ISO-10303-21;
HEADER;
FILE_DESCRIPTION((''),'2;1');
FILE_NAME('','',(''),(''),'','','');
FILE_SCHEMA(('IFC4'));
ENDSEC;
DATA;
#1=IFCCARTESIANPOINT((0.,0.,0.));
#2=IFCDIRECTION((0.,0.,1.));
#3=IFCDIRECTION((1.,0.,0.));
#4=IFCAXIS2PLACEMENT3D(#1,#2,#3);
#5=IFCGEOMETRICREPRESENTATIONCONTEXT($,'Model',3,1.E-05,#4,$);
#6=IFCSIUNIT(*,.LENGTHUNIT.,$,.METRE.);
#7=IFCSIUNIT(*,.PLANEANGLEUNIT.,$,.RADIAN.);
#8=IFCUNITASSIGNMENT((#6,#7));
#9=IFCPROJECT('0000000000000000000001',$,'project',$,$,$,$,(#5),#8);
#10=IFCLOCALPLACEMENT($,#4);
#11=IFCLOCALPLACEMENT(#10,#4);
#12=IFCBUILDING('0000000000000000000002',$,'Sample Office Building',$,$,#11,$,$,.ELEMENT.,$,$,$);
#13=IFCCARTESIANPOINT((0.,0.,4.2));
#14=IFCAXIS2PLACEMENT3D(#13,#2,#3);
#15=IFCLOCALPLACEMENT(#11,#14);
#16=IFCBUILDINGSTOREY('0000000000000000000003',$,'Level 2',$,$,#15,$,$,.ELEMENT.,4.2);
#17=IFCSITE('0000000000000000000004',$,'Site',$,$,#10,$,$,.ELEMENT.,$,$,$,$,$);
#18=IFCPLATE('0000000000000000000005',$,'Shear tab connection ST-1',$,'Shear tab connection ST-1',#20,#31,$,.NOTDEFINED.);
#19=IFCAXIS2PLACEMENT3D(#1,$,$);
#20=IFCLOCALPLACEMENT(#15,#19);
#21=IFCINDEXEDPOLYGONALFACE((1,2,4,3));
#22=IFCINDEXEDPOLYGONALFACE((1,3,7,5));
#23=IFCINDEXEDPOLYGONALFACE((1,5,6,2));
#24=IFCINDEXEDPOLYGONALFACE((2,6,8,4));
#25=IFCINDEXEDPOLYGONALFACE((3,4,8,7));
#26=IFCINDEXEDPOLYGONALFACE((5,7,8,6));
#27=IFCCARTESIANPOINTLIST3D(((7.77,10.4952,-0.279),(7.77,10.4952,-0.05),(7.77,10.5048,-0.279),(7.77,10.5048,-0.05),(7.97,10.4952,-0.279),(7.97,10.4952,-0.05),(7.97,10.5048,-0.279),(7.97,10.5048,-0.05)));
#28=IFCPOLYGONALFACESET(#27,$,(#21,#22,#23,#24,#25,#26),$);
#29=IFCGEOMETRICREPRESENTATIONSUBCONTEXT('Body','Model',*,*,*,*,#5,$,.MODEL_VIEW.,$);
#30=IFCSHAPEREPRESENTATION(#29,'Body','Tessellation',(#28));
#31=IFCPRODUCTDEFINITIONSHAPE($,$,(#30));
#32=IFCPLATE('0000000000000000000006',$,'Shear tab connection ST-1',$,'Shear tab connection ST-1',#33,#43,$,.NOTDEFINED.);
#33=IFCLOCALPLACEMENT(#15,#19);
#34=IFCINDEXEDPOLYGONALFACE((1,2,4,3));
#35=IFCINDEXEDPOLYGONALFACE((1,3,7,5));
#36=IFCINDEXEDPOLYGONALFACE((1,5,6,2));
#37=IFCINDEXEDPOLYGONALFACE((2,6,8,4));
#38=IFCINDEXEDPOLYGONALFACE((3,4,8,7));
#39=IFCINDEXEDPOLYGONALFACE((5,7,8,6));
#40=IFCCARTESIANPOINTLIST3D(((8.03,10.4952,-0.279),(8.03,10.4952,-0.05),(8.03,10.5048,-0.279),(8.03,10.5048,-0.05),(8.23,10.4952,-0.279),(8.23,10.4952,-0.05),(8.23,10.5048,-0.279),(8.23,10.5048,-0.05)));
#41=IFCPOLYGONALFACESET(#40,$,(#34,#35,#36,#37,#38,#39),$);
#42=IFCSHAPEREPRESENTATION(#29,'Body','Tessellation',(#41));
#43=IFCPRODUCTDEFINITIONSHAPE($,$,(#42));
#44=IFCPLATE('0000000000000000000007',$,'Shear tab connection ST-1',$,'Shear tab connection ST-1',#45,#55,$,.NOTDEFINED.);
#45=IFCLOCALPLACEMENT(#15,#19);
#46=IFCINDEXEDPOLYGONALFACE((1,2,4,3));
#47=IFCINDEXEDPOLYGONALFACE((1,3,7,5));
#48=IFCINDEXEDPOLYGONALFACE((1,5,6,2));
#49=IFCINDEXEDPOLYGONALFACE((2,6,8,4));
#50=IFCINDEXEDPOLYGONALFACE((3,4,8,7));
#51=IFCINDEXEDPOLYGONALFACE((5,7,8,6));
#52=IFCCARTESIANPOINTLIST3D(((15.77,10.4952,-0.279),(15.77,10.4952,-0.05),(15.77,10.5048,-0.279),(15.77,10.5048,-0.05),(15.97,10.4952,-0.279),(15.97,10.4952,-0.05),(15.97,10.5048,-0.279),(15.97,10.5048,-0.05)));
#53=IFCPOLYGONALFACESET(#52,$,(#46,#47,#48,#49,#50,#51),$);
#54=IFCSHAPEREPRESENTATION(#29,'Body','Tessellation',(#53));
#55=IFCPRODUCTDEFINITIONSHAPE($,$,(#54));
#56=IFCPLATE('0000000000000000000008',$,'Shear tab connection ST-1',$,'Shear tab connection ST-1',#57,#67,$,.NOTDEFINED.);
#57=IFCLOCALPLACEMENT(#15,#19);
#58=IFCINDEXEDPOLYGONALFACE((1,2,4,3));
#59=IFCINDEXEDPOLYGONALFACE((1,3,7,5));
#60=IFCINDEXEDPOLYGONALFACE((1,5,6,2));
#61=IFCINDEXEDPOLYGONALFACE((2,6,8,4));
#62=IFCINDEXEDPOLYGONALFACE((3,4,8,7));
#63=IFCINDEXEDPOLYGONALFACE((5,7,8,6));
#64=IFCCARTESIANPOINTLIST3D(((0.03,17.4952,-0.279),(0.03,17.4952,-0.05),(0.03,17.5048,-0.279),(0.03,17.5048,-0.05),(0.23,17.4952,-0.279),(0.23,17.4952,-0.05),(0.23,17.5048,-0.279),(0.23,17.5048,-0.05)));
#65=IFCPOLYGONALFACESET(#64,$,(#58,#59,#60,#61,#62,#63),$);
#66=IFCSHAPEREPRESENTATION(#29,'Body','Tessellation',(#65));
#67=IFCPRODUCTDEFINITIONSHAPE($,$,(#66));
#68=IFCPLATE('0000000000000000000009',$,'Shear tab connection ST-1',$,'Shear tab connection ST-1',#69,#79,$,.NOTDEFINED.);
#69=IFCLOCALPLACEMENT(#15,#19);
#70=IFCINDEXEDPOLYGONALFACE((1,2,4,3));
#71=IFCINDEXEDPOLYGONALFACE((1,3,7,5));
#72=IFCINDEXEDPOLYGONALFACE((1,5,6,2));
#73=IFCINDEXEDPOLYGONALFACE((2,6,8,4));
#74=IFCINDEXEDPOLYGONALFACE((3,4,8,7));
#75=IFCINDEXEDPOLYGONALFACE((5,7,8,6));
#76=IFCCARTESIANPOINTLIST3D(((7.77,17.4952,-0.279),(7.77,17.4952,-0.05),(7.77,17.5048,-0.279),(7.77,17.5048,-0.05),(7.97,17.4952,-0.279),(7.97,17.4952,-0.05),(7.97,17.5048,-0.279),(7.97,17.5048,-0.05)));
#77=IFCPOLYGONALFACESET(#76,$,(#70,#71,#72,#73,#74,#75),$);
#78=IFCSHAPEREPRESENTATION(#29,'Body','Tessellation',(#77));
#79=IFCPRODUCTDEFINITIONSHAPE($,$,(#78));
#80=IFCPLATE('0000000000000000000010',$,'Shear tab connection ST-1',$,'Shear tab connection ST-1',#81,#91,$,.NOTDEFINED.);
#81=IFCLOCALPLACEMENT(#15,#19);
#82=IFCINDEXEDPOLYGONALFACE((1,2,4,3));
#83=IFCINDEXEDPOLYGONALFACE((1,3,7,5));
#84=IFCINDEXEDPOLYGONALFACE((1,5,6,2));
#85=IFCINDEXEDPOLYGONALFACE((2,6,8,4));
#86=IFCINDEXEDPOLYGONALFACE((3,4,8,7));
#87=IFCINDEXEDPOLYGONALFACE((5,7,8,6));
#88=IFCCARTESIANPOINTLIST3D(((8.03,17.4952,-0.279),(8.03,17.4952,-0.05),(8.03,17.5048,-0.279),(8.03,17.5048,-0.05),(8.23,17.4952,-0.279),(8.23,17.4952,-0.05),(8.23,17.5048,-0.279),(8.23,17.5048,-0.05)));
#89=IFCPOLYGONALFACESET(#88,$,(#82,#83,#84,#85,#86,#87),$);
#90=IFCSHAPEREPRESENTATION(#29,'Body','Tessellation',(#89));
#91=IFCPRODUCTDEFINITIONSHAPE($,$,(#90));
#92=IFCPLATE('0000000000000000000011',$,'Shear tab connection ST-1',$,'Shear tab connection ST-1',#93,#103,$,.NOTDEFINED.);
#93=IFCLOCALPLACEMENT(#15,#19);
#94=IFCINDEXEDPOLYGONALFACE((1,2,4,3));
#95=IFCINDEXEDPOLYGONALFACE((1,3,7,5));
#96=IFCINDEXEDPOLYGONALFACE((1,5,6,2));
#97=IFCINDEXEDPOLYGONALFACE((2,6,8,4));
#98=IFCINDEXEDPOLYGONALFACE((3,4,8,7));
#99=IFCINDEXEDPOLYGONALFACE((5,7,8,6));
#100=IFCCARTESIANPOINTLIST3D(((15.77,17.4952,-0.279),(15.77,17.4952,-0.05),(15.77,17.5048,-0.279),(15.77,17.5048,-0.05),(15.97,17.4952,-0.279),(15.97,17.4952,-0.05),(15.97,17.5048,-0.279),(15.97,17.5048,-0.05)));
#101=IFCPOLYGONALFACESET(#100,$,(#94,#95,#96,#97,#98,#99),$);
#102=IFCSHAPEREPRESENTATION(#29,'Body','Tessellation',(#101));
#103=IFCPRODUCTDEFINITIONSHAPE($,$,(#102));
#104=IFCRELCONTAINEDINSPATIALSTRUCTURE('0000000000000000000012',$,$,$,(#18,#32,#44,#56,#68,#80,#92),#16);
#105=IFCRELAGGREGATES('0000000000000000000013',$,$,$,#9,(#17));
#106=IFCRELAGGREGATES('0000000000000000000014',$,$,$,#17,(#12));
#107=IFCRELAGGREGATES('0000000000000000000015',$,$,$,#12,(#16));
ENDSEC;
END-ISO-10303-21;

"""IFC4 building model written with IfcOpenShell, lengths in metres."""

from ifc_helpers import new_model, si_unit, frame, origin_with_axes, place, context, subcontext, project, spatial, rectangle, extrude, element, save


model = new_model("IFC4")

# Units and contexts
model_context = context("Model", 3, precision=1e-05, world=origin_with_axes())
body_context = subcontext(model_context, "Body", "Model", "MODEL_VIEW")
ifc_project = project(units=[si_unit("LENGTHUNIT", "METRE"), si_unit("PLANEANGLEUNIT", "RADIAN")], contexts=[model_context])

# Site, building, storey
site_placement = place(None, origin_with_axes())
site = spatial("IfcSite", under=ifc_project, at=site_placement, Name="Site", CompositionType="ELEMENT")
building_placement = place(site_placement, origin_with_axes())
building = spatial("IfcBuilding", under=site, at=building_placement, Name="Sample Office Building", CompositionType="ELEMENT")
storey_placement = place(building_placement, frame((0.0, 0.0, 4.2), z_axis=(0.0, 0.0, 1.0), x_axis=(1.0, 0.0, 0.0)))
storey = spatial("IfcBuildingStorey", under=building, at=storey_placement, Name="Level 2", CompositionType="ELEMENT", Elevation=4.2)

# Plates
plate_1_placement = place(None, frame((7.87, 10.5, 3.921), z_axis=(0.0, 0.0, 1.0), x_axis=(1.0, 0.0, 0.0)))
element("IfcPlate", 1, at=plate_1_placement, inside=storey, Name="Shear tab connection ST-1", ObjectType="Shear tab connection ST-1", PredefinedType="NOTDEFINED", context=body_context, shape_type="SweptSolid", body=[
    extrude(rectangle(XDim=0.2, YDim=0.0095), None, (0.0, 0.0, 1.0), 0.229),
])
for number, where, z_axis, x_axis, name in (
    (2, (8.13, 10.5, 3.921), (0.0, 0.0, 1.0), (1.0, 0.0, 0.0), "Shear tab connection ST-1"),
    (3, (15.87, 10.5, 3.921), (0.0, 0.0, 1.0), (1.0, 0.0, 0.0), "Shear tab connection ST-1"),
):
    element("IfcPlate", number, at=place(None, frame(where, z_axis=z_axis, x_axis=x_axis)), inside=storey, Name=name, ObjectType="Shear tab connection ST-1", PredefinedType="NOTDEFINED", context=body_context, shape_type="SweptSolid", body=[
        extrude(rectangle(XDim=0.2, YDim=0.0095), None, (0.0, 0.0, 1.0), 0.229),
    ])
plate_2_placement = place(None, frame((0.13, 17.5, 3.921), z_axis=(0.0, 0.0, 1.0), x_axis=(1.0, 0.0, 0.0)))
element("IfcPlate", 4, at=plate_2_placement, inside=storey, Name="Shear tab connection ST-1", ObjectType="Shear tab connection ST-1", PredefinedType="NOTDEFINED", context=body_context, shape_type="SweptSolid", body=[
    extrude(rectangle(XDim=0.2, YDim=0.0095), None, (0.0, 0.0, 1.0), 0.229),
])
plate_3_placement = place(None, frame((7.87, 17.5, 3.921), z_axis=(0.0, 0.0, 1.0), x_axis=(1.0, 0.0, 0.0)))
element("IfcPlate", 5, at=plate_3_placement, inside=storey, Name="Shear tab connection ST-1", ObjectType="Shear tab connection ST-1", PredefinedType="NOTDEFINED", context=body_context, shape_type="SweptSolid", body=[
    extrude(rectangle(XDim=0.2, YDim=0.0095), None, (0.0, 0.0, 1.0), 0.229),
])
for number, where, z_axis, x_axis, name in (
    (6, (8.13, 17.5, 3.921), (0.0, 0.0, 1.0), (1.0, 0.0, 0.0), "Shear tab connection ST-1"),
    (7, (15.87, 17.5, 3.921), (0.0, 0.0, 1.0), (1.0, 0.0, 0.0), "Shear tab connection ST-1"),
):
    element("IfcPlate", number, at=place(None, frame(where, z_axis=z_axis, x_axis=x_axis)), inside=storey, Name=name, ObjectType="Shear tab connection ST-1", PredefinedType="NOTDEFINED", context=body_context, shape_type="SweptSolid", body=[
        extrude(rectangle(XDim=0.2, YDim=0.0095), None, (0.0, 0.0, 1.0), 0.229),
    ])

save(model, "model.ifc")
